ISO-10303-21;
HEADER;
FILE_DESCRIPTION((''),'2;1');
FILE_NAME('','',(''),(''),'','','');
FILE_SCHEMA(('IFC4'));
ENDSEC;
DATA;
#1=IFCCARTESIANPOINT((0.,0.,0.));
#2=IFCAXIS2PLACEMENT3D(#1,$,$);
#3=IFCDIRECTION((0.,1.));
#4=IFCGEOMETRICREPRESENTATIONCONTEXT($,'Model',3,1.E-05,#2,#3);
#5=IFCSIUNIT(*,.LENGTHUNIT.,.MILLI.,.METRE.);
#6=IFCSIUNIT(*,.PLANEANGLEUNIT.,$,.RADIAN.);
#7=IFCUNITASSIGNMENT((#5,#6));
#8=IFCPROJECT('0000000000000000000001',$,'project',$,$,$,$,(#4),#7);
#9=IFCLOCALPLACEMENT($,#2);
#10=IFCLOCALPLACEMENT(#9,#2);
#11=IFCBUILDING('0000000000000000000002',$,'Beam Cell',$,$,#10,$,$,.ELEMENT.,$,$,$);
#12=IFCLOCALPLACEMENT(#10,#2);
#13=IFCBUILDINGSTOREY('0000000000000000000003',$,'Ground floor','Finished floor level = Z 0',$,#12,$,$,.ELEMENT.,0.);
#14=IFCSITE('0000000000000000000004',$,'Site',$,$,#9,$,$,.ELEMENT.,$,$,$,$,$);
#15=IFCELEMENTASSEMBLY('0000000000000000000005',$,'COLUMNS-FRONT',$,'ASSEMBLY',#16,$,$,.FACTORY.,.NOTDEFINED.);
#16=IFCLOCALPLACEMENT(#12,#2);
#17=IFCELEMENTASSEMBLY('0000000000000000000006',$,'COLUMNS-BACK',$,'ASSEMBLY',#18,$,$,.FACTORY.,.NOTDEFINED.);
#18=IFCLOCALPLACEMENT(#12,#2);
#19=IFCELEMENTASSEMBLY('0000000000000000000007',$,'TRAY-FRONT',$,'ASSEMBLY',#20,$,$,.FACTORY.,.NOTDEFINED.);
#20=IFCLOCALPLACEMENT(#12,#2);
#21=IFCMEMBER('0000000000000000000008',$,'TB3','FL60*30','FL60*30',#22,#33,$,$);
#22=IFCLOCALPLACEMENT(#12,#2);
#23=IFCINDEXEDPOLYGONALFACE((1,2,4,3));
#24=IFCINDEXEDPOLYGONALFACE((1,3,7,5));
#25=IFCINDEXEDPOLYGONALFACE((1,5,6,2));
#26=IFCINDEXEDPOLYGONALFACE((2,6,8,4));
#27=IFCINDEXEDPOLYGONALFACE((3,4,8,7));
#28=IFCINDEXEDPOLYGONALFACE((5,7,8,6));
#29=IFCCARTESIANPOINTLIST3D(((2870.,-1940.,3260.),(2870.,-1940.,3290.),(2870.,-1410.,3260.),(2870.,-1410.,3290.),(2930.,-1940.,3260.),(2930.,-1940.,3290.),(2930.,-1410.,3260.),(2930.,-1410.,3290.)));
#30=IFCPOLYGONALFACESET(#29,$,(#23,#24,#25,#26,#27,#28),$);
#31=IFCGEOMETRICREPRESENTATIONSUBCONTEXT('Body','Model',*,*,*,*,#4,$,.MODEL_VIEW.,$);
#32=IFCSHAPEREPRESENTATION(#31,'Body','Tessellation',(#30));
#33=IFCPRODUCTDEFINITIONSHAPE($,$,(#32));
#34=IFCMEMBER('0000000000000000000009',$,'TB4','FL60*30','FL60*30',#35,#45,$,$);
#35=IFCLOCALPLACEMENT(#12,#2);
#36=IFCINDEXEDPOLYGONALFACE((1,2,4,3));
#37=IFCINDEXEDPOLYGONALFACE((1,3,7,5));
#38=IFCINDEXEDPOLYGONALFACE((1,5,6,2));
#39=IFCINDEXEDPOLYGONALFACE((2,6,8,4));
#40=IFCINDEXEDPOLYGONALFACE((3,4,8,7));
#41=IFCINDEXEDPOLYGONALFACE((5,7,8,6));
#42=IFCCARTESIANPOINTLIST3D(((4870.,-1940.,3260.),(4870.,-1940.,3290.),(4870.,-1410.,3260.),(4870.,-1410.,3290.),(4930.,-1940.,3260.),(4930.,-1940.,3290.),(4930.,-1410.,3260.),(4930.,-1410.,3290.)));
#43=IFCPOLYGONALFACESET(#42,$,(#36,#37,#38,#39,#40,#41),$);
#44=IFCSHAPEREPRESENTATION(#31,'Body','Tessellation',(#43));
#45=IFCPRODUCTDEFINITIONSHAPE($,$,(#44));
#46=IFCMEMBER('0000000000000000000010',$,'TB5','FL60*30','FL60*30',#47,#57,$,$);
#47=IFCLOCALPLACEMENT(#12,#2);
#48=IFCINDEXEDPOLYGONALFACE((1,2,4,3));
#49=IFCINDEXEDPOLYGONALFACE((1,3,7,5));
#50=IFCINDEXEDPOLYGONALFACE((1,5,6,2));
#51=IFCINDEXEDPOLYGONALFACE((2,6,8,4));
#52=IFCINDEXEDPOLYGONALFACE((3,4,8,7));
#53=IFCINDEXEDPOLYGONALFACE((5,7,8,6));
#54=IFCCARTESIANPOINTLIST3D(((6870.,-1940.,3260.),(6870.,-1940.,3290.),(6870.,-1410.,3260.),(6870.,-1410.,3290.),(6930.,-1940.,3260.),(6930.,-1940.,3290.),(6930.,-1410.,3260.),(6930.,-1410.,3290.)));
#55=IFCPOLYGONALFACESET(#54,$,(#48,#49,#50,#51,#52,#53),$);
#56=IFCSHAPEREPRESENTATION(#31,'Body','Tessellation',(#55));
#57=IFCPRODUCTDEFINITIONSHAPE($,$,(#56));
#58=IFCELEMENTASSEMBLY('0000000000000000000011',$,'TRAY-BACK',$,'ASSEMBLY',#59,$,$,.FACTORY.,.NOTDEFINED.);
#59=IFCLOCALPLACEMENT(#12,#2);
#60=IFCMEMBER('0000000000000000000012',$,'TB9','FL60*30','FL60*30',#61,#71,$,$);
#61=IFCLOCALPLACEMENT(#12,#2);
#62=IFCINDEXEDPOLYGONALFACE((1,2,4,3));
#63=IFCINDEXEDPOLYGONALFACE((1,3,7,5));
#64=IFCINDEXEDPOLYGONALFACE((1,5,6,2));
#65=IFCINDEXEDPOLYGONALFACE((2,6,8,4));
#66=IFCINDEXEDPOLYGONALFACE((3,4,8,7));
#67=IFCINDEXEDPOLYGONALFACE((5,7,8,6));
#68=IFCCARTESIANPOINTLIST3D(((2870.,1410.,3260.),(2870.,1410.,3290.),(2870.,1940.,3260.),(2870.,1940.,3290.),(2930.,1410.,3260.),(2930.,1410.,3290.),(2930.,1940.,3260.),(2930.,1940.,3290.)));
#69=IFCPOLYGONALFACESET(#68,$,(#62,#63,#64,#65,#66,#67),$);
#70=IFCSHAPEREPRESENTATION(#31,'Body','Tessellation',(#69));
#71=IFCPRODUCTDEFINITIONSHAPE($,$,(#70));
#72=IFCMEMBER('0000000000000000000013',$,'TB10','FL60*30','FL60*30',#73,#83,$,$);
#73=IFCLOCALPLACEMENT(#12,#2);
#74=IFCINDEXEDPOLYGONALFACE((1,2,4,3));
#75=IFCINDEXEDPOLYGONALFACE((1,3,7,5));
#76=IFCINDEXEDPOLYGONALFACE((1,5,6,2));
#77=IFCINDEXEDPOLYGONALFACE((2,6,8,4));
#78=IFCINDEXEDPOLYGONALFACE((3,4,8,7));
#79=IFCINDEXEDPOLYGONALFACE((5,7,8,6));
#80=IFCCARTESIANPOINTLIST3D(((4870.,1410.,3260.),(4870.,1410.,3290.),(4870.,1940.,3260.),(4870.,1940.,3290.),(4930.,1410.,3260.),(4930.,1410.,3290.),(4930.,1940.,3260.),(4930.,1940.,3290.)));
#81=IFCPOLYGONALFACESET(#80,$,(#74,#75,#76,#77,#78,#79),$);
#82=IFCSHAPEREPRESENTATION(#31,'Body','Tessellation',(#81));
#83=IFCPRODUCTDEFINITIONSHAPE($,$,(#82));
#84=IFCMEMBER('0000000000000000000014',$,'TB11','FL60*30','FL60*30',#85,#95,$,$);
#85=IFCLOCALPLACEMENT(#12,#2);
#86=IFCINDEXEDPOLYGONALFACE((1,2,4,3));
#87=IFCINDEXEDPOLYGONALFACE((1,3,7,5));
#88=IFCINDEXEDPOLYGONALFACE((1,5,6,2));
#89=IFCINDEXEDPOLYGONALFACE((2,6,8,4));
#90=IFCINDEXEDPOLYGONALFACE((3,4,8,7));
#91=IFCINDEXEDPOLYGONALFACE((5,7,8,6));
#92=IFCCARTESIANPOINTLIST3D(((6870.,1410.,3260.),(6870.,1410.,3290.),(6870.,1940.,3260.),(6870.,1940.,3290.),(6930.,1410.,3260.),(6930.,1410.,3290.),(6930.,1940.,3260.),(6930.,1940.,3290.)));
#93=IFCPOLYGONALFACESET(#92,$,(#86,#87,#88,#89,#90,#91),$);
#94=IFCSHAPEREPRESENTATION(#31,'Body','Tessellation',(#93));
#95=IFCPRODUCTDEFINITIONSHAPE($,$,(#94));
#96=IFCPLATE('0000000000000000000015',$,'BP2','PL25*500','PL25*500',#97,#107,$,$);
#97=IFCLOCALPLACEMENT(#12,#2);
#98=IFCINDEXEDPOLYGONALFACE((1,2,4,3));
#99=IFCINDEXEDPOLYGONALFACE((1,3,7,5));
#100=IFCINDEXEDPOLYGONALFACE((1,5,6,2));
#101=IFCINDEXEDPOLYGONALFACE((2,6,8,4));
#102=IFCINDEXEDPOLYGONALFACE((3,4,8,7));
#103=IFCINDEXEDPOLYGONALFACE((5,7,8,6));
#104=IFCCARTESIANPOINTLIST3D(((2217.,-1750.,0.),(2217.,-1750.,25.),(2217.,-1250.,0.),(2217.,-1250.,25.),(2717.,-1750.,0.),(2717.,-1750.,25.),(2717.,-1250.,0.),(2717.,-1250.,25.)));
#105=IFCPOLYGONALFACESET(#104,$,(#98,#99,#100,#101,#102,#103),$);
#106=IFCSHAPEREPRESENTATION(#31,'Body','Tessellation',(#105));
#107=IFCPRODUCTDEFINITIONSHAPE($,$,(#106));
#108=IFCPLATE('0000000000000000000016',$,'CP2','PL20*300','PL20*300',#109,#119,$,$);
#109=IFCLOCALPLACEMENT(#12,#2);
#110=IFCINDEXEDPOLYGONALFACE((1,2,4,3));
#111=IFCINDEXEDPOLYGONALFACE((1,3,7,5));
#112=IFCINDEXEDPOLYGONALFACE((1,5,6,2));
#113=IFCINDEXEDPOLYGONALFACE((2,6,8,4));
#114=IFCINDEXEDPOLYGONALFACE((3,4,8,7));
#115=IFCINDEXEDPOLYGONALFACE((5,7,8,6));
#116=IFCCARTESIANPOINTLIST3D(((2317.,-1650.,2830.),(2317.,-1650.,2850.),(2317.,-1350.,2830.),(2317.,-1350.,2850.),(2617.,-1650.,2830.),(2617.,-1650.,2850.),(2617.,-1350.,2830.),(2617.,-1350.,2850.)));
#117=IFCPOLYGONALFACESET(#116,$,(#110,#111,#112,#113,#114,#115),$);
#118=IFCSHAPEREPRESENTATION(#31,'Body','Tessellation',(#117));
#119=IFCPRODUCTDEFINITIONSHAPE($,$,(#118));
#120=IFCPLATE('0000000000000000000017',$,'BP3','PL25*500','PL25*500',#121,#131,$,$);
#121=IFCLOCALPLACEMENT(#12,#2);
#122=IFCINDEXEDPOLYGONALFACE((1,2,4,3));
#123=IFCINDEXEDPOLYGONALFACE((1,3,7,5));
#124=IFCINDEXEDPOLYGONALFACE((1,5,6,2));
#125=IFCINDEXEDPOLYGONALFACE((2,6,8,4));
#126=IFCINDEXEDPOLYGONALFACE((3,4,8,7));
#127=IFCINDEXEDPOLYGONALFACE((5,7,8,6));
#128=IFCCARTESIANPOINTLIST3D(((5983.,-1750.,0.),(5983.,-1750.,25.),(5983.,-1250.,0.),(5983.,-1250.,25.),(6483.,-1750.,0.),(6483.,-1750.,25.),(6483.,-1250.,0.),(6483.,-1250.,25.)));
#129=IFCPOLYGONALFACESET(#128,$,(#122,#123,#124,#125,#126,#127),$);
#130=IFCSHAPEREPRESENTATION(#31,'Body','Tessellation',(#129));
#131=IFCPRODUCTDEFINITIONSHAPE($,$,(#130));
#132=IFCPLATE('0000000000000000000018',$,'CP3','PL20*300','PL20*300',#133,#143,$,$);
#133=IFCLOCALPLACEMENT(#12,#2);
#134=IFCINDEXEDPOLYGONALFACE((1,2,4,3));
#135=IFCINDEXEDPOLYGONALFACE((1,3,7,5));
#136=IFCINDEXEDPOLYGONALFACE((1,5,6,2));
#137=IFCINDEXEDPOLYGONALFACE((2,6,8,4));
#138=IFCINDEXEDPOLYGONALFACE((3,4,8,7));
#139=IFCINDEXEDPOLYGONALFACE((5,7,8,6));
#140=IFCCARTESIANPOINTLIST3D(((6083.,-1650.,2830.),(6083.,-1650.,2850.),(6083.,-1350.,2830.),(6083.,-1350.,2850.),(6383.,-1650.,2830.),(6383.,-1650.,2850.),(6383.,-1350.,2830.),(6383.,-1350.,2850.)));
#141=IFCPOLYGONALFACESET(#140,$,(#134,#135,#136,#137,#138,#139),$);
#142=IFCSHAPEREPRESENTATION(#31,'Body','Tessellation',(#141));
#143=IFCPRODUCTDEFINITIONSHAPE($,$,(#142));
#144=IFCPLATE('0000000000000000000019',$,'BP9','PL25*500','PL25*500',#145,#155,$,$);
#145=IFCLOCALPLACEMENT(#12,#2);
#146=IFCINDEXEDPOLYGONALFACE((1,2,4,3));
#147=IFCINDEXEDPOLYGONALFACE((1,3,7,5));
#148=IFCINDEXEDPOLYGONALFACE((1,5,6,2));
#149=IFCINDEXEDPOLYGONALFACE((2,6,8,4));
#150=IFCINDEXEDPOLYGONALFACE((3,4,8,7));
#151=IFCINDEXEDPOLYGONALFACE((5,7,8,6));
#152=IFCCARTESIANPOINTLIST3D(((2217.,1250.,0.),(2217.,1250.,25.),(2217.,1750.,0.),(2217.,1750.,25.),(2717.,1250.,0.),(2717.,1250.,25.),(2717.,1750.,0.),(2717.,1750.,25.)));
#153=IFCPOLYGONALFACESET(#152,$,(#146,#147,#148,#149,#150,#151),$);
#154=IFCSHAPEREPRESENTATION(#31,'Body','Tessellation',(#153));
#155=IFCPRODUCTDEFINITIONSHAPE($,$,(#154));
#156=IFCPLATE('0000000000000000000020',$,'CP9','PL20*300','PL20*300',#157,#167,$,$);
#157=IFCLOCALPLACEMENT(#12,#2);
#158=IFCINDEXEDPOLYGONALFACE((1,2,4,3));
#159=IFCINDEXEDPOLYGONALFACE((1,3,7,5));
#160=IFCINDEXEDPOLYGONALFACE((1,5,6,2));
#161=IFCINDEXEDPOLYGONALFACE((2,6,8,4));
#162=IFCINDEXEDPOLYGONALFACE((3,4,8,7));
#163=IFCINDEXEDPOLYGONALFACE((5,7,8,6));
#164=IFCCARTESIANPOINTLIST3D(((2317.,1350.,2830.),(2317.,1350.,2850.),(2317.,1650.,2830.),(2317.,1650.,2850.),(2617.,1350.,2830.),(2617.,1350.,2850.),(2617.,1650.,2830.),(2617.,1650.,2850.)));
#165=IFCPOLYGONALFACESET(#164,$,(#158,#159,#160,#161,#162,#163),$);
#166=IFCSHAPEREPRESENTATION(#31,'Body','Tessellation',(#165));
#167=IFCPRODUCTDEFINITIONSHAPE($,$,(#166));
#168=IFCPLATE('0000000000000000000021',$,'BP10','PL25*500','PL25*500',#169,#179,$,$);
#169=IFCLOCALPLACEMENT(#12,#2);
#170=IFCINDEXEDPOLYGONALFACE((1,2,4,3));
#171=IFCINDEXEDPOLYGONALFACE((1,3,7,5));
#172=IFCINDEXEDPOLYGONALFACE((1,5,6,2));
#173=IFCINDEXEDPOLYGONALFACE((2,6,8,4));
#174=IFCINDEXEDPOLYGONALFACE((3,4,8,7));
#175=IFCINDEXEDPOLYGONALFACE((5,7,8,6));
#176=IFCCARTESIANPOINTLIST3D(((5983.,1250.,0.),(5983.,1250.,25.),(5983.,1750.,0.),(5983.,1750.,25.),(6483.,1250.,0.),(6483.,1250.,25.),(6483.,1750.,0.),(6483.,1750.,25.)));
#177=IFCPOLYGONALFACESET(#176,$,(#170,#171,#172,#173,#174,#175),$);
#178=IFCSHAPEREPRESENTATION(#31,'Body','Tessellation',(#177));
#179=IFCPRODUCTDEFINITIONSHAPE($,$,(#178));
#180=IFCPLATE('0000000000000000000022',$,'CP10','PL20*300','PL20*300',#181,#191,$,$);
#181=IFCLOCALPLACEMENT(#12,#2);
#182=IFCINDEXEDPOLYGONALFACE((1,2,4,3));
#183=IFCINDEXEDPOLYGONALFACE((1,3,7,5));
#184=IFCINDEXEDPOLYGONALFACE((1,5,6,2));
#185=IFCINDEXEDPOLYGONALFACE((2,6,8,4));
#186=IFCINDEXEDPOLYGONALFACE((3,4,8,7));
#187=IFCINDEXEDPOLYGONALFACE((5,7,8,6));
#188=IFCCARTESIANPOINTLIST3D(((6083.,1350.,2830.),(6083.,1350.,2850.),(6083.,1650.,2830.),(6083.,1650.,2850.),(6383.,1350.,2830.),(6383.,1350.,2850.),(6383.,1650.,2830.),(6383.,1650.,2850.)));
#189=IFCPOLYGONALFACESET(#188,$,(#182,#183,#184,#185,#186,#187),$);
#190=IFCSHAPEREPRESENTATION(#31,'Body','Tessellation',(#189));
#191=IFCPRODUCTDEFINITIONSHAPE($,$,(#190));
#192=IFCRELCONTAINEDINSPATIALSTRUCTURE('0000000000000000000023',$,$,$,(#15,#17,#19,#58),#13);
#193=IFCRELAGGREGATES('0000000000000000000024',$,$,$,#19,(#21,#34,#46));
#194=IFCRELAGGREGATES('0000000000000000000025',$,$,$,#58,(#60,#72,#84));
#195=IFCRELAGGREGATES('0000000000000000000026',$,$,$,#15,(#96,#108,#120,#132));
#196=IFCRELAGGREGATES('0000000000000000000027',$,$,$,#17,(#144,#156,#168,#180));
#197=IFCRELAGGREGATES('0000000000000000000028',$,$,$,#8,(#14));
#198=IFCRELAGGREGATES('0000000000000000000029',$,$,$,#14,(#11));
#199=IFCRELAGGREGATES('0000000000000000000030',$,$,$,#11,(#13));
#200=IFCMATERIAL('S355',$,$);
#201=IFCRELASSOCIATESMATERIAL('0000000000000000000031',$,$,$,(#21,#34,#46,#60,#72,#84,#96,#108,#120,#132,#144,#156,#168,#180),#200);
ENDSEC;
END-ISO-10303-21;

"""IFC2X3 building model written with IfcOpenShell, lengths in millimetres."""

from ifc_helpers import new_model, si_unit, direction, frame, origin, origin_2d, place, context, subcontext, project, spatial, rectangle, extrude, material, element, aggregate, save


model = new_model("IFC2X3")

# Units and contexts
model_context = context("Model", 3, precision=1e-05, world=origin(), true_north=direction((0.0, 1.0)))
body_context = subcontext(model_context, "Body", "Model", "MODEL_VIEW")
ifc_project = project(units=[si_unit("LENGTHUNIT", "METRE", prefix="MILLI"), si_unit("PLANEANGLEUNIT", "RADIAN")], contexts=[model_context])

# Site, building, storey
site_placement = place(None, origin())
site = spatial("IfcSite", under=ifc_project, at=site_placement, Name="Site", CompositionType="ELEMENT")
building_placement = place(site_placement, origin())
building = spatial("IfcBuilding", under=site, at=building_placement, Name="Beam Cell", CompositionType="ELEMENT")
storey_placement = place(building_placement, origin())
storey = spatial("IfcBuildingStorey", under=building, at=storey_placement, Name="Ground floor", Description="Finished floor level = Z 0", CompositionType="ELEMENT", Elevation=0.0)

# Element assemblies
assembly_1_placement = place(storey_placement, origin())
assembly_1 = element("IfcElementAssembly", 1, at=assembly_1_placement, inside=storey, Name="COLUMNS-FRONT", ObjectType="ASSEMBLY", AssemblyPlace="FACTORY", PredefinedType="NOTDEFINED")
ifc_material = material(Name="S355")
assembly_2_placement = place(storey_placement, origin())
assembly_2 = element("IfcElementAssembly", 2, at=assembly_2_placement, inside=storey, Name="COLUMNS-BACK", ObjectType="ASSEMBLY", AssemblyPlace="FACTORY", PredefinedType="NOTDEFINED")

# Element assemblies, members
assembly_3_placement = place(storey_placement, origin())
assembly_3 = element("IfcElementAssembly", 3, at=assembly_3_placement, inside=storey, Name="TRAY-FRONT", ObjectType="ASSEMBLY", AssemblyPlace="FACTORY", PredefinedType="NOTDEFINED")
member_1_placement = place(storey_placement, frame((2900.0, -1940.0, 3275.0), z_axis=(0.0, 1.0, 0.0), x_axis=(1.0, 0.0, 0.0)))
member_1 = element("IfcMember", 4, at=member_1_placement, material=ifc_material, Name="TB3", Description="FL60*30", ObjectType="FL60*30", context=body_context, shape_type="SweptSolid", body=[
    extrude(rectangle(XDim=60.0, YDim=30.0, at=origin_2d()), origin(), (0.0, 0.0, 1.0), 530.0),
])
member_2_placement = place(storey_placement, frame((4900.0, -1940.0, 3275.0), z_axis=(0.0, 1.0, 0.0), x_axis=(1.0, 0.0, 0.0)))
member_2 = element("IfcMember", 5, at=member_2_placement, material=ifc_material, Name="TB4", Description="FL60*30", ObjectType="FL60*30", context=body_context, shape_type="SweptSolid", body=[
    extrude(rectangle(XDim=60.0, YDim=30.0, at=origin_2d()), origin(), (0.0, 0.0, 1.0), 530.0),
])
member_3_placement = place(storey_placement, frame((6900.0, -1940.0, 3275.0), z_axis=(0.0, 1.0, 0.0), x_axis=(1.0, 0.0, 0.0)))
member_3 = element("IfcMember", 6, at=member_3_placement, material=ifc_material, Name="TB5", Description="FL60*30", ObjectType="FL60*30", context=body_context, shape_type="SweptSolid", body=[
    extrude(rectangle(XDim=60.0, YDim=30.0, at=origin_2d()), origin(), (0.0, 0.0, 1.0), 530.0),
])
aggregate(assembly_3, [member_1, member_2, member_3])
assembly_4_placement = place(storey_placement, origin())
assembly_4 = element("IfcElementAssembly", 7, at=assembly_4_placement, inside=storey, Name="TRAY-BACK", ObjectType="ASSEMBLY", AssemblyPlace="FACTORY", PredefinedType="NOTDEFINED")
member_4_placement = place(storey_placement, frame((2900.0, 1410.0, 3275.0), z_axis=(0.0, 1.0, 0.0), x_axis=(1.0, 0.0, 0.0)))
member_4 = element("IfcMember", 8, at=member_4_placement, material=ifc_material, Name="TB9", Description="FL60*30", ObjectType="FL60*30", context=body_context, shape_type="SweptSolid", body=[
    extrude(rectangle(XDim=60.0, YDim=30.0, at=origin_2d()), origin(), (0.0, 0.0, 1.0), 530.0),
])
member_5_placement = place(storey_placement, frame((4900.0, 1410.0, 3275.0), z_axis=(0.0, 1.0, 0.0), x_axis=(1.0, 0.0, 0.0)))
member_5 = element("IfcMember", 9, at=member_5_placement, material=ifc_material, Name="TB10", Description="FL60*30", ObjectType="FL60*30", context=body_context, shape_type="SweptSolid", body=[
    extrude(rectangle(XDim=60.0, YDim=30.0, at=origin_2d()), origin(), (0.0, 0.0, 1.0), 530.0),
])
member_6_placement = place(storey_placement, frame((6900.0, 1410.0, 3275.0), z_axis=(0.0, 1.0, 0.0), x_axis=(1.0, 0.0, 0.0)))
member_6 = element("IfcMember", 10, at=member_6_placement, material=ifc_material, Name="TB11", Description="FL60*30", ObjectType="FL60*30", context=body_context, shape_type="SweptSolid", body=[
    extrude(rectangle(XDim=60.0, YDim=30.0, at=origin_2d()), origin(), (0.0, 0.0, 1.0), 530.0),
])
aggregate(assembly_4, [member_4, member_5, member_6])

# Plates
plate_1_placement = place(storey_placement, frame((2467.0, -1500.0, 0.0), z_axis=(0.0, 0.0, 1.0), x_axis=(1.0, 0.0, 0.0)))
plate_1 = element("IfcPlate", 11, at=plate_1_placement, material=ifc_material, Name="BP2", Description="PL25*500", ObjectType="PL25*500", context=body_context, shape_type="SweptSolid", body=[
    extrude(rectangle(XDim=500.0, YDim=500.0, at=origin_2d()), origin(), (0.0, 0.0, 1.0), 25.0),
])
plate_2_placement = place(storey_placement, frame((2467.0, -1500.0, 2830.0), z_axis=(0.0, 0.0, 1.0), x_axis=(1.0, 0.0, 0.0)))
plate_2 = element("IfcPlate", 12, at=plate_2_placement, material=ifc_material, Name="CP2", Description="PL20*300", ObjectType="PL20*300", context=body_context, shape_type="SweptSolid", body=[
    extrude(rectangle(XDim=300.0, YDim=300.0, at=origin_2d()), origin(), (0.0, 0.0, 1.0), 20.0),
])
plate_3_placement = place(storey_placement, frame((6233.0, -1500.0, 0.0), z_axis=(0.0, 0.0, 1.0), x_axis=(1.0, 0.0, 0.0)))
plate_3 = element("IfcPlate", 13, at=plate_3_placement, material=ifc_material, Name="BP3", Description="PL25*500", ObjectType="PL25*500", context=body_context, shape_type="SweptSolid", body=[
    extrude(rectangle(XDim=500.0, YDim=500.0, at=origin_2d()), origin(), (0.0, 0.0, 1.0), 25.0),
])
plate_4_placement = place(storey_placement, frame((6233.0, -1500.0, 2830.0), z_axis=(0.0, 0.0, 1.0), x_axis=(1.0, 0.0, 0.0)))
plate_4 = element("IfcPlate", 14, at=plate_4_placement, material=ifc_material, Name="CP3", Description="PL20*300", ObjectType="PL20*300", context=body_context, shape_type="SweptSolid", body=[
    extrude(rectangle(XDim=300.0, YDim=300.0, at=origin_2d()), origin(), (0.0, 0.0, 1.0), 20.0),
])
aggregate(assembly_1, [plate_1, plate_2, plate_3, plate_4])
plate_5_placement = place(storey_placement, frame((2467.0, 1500.0, 0.0), z_axis=(0.0, 0.0, 1.0), x_axis=(1.0, 0.0, 0.0)))
plate_5 = element("IfcPlate", 15, at=plate_5_placement, material=ifc_material, Name="BP9", Description="PL25*500", ObjectType="PL25*500", context=body_context, shape_type="SweptSolid", body=[
    extrude(rectangle(XDim=500.0, YDim=500.0, at=origin_2d()), origin(), (0.0, 0.0, 1.0), 25.0),
])
plate_6_placement = place(storey_placement, frame((2467.0, 1500.0, 2830.0), z_axis=(0.0, 0.0, 1.0), x_axis=(1.0, 0.0, 0.0)))
plate_6 = element("IfcPlate", 16, at=plate_6_placement, material=ifc_material, Name="CP9", Description="PL20*300", ObjectType="PL20*300", context=body_context, shape_type="SweptSolid", body=[
    extrude(rectangle(XDim=300.0, YDim=300.0, at=origin_2d()), origin(), (0.0, 0.0, 1.0), 20.0),
])
plate_7_placement = place(storey_placement, frame((6233.0, 1500.0, 0.0), z_axis=(0.0, 0.0, 1.0), x_axis=(1.0, 0.0, 0.0)))
plate_7 = element("IfcPlate", 17, at=plate_7_placement, material=ifc_material, Name="BP10", Description="PL25*500", ObjectType="PL25*500", context=body_context, shape_type="SweptSolid", body=[
    extrude(rectangle(XDim=500.0, YDim=500.0, at=origin_2d()), origin(), (0.0, 0.0, 1.0), 25.0),
])
plate_8_placement = place(storey_placement, frame((6233.0, 1500.0, 2830.0), z_axis=(0.0, 0.0, 1.0), x_axis=(1.0, 0.0, 0.0)))
plate_8 = element("IfcPlate", 18, at=plate_8_placement, material=ifc_material, Name="CP10", Description="PL20*300", ObjectType="PL20*300", context=body_context, shape_type="SweptSolid", body=[
    extrude(rectangle(XDim=300.0, YDim=300.0, at=origin_2d()), origin(), (0.0, 0.0, 1.0), 20.0),
])
aggregate(assembly_2, [plate_5, plate_6, plate_7, plate_8])

save(model, "model.ifc")
